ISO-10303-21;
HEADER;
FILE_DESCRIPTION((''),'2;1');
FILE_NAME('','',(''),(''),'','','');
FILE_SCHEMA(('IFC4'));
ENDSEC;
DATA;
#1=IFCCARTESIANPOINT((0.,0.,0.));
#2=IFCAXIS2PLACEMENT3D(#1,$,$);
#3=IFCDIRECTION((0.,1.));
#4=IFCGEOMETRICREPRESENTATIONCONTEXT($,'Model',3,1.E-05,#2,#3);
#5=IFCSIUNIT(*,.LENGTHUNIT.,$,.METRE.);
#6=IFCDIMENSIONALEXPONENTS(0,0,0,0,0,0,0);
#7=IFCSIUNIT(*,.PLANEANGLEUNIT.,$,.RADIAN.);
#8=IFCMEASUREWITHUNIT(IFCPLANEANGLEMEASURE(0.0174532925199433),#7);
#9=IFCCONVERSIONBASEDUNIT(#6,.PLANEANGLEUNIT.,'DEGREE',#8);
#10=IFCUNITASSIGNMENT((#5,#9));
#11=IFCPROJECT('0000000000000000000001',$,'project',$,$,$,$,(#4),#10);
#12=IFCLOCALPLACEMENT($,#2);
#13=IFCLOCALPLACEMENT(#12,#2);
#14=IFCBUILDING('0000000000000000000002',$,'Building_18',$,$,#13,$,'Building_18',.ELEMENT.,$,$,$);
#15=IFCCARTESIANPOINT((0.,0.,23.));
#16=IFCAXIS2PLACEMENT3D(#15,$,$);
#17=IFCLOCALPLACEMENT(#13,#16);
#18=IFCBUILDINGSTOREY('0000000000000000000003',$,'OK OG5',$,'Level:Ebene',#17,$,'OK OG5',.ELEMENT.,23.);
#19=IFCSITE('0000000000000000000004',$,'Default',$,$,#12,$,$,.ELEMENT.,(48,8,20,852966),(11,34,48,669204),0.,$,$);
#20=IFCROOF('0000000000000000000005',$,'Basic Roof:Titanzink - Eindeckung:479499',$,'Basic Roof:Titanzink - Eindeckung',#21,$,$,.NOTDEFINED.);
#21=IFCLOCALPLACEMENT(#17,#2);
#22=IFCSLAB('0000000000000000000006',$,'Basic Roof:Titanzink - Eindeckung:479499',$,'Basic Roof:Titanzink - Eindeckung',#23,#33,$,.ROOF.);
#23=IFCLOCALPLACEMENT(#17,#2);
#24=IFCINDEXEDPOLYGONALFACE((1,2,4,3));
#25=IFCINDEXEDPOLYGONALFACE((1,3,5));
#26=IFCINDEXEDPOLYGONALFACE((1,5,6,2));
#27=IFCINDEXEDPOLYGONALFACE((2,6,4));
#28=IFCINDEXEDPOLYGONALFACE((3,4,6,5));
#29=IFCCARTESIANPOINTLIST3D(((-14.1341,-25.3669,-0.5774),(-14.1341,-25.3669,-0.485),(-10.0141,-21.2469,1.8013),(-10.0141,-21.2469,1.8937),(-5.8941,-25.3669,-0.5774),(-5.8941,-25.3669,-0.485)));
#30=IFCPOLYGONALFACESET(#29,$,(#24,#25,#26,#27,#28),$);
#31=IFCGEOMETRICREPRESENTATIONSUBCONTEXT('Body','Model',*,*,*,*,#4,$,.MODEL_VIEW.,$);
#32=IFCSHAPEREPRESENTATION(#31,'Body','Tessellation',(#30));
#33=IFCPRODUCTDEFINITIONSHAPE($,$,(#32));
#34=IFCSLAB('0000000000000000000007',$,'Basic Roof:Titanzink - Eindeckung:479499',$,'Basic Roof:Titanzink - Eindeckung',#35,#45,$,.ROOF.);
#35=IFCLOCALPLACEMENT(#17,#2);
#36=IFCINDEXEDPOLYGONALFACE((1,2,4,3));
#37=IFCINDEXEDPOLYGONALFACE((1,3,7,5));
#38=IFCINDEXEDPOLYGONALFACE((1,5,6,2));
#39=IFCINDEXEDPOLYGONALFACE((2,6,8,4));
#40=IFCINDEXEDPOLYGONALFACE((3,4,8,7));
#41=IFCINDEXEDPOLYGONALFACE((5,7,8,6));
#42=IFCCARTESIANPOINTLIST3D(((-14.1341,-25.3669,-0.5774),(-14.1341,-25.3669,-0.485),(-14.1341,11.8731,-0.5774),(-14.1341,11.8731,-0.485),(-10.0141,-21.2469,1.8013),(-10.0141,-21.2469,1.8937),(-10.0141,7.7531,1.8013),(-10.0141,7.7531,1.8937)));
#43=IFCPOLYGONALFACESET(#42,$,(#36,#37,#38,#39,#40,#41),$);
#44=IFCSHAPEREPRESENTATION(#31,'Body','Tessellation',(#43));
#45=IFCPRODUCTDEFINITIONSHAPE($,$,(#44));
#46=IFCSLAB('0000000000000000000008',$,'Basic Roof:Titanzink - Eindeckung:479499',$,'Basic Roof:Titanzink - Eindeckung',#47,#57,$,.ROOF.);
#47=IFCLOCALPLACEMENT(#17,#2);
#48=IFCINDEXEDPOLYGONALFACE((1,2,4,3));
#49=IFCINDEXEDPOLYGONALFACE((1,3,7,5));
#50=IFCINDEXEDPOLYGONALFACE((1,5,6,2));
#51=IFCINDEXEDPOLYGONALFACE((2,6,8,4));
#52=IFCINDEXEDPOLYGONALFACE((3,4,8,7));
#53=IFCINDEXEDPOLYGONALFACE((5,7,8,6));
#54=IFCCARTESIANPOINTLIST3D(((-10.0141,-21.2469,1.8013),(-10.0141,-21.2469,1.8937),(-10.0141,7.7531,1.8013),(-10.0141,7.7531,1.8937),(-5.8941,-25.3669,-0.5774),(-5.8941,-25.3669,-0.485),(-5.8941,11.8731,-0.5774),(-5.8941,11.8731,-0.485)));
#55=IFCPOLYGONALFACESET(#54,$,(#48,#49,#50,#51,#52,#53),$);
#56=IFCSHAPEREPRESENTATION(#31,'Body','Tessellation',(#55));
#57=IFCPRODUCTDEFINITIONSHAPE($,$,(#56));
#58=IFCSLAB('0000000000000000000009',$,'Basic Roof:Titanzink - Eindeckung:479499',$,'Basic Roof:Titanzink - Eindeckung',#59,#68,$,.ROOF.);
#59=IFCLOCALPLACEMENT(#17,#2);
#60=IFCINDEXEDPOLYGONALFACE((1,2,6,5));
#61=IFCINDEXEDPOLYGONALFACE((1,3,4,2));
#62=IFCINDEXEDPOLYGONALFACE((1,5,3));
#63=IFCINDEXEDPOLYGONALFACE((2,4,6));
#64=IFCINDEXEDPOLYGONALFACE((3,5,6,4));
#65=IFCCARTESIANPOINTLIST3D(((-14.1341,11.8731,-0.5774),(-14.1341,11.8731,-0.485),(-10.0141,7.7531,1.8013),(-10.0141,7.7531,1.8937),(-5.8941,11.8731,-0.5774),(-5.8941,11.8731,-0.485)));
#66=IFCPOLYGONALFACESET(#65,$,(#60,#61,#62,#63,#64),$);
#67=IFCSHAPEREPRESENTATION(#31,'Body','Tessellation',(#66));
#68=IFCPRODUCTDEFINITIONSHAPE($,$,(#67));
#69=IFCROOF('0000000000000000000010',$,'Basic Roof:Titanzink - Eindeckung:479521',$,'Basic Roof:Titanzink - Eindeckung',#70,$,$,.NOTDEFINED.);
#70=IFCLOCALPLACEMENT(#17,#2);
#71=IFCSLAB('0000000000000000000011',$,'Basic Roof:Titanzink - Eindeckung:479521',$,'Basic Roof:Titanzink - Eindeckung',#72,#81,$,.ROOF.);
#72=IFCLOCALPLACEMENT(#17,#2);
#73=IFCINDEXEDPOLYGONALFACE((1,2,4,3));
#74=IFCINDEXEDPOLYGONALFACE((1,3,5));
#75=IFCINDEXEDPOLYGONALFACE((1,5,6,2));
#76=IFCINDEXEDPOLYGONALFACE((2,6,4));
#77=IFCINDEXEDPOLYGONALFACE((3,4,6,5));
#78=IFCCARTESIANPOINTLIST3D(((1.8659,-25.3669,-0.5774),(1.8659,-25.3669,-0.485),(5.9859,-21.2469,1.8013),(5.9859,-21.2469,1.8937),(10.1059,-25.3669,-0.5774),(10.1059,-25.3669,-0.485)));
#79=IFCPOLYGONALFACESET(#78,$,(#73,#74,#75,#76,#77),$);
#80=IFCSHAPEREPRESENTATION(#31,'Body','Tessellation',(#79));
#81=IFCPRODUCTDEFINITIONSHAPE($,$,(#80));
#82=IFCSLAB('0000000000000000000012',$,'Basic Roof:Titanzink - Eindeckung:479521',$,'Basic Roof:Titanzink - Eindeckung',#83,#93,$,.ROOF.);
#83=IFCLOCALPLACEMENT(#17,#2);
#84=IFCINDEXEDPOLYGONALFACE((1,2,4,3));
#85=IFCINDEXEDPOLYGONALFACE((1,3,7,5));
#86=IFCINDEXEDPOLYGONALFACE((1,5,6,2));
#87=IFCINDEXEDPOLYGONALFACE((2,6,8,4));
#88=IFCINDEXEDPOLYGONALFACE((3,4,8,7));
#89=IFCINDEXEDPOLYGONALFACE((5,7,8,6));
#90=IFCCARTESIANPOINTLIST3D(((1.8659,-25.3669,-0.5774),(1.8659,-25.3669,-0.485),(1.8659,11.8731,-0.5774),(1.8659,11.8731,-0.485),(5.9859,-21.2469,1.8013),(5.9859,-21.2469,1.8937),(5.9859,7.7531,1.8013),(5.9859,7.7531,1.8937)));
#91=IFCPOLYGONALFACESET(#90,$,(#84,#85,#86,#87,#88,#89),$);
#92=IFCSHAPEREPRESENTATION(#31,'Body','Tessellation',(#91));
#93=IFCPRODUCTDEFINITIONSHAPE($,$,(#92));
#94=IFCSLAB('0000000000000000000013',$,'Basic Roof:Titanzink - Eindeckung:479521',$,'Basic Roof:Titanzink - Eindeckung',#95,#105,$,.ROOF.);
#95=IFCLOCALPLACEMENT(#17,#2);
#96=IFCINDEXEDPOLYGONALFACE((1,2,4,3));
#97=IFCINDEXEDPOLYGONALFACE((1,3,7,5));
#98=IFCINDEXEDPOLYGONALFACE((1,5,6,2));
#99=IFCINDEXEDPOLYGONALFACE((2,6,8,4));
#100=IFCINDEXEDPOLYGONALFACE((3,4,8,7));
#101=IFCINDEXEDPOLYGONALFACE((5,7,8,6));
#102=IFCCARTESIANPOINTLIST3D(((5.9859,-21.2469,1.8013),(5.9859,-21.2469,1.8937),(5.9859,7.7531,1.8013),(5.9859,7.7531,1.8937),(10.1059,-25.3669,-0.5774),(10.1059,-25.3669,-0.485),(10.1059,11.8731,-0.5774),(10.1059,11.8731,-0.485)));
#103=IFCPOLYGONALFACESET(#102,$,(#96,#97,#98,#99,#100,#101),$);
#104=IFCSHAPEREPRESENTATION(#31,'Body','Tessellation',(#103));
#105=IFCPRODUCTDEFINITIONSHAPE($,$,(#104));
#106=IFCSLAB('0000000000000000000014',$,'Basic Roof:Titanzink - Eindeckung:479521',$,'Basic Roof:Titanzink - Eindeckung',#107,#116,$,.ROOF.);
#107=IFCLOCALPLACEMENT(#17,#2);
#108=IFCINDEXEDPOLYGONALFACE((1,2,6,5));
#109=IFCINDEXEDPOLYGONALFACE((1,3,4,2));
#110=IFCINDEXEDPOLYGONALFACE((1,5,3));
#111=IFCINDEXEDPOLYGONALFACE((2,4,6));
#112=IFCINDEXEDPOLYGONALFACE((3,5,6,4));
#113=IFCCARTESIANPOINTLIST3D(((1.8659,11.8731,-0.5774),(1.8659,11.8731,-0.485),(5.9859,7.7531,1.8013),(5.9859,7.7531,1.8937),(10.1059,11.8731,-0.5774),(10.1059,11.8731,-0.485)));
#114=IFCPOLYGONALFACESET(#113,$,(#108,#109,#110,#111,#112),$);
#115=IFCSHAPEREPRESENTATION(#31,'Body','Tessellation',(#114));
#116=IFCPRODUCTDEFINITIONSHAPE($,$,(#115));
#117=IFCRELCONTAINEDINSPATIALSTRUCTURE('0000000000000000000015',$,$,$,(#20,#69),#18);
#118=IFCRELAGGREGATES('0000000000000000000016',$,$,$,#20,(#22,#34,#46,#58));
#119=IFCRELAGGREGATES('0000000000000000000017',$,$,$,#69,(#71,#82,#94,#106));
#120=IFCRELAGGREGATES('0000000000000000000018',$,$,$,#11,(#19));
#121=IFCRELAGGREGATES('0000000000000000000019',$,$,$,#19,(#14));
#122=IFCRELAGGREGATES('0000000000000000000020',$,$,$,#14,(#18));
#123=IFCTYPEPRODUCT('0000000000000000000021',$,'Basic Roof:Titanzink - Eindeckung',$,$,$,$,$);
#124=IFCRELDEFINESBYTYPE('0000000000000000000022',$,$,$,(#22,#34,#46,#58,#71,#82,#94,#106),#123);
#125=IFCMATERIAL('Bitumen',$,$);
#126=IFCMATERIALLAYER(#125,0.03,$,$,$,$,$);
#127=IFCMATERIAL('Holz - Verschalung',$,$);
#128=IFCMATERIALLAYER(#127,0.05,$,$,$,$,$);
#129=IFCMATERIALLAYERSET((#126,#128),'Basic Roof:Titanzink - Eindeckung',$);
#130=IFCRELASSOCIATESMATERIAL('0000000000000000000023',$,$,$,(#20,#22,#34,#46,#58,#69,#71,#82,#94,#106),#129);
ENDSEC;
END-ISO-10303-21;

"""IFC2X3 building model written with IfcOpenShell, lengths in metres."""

from ifc_helpers import new_model, entity, si_unit, converted_unit, direction, frame, origin, place, context, subcontext, project, spatial, polyline, outline, extrude, material, layer, layer_set, type_object, element, aggregate, save


model = new_model("IFC2X3")

# Units and contexts
model_context = context("Model", 3, precision=1e-05, world=origin(), true_north=direction((0.0, 1.0)))
body_context = subcontext(model_context, "Body", "Model", "MODEL_VIEW")
ifc_project = project(units=[si_unit("LENGTHUNIT", "METRE"), converted_unit("PLANEANGLEUNIT", "DEGREE", entity("IfcPlaneAngleMeasure", 0.0174532925199433), si_unit("PLANEANGLEUNIT", "RADIAN"), dimensions=[0, 0, 0, 0, 0, 0, 0])], contexts=[model_context])

# Site, building, storey
site_placement = place(None, origin())
site = spatial("IfcSite", under=ifc_project, at=site_placement, Name="Default", CompositionType="ELEMENT", RefLatitude=(48, 8, 20, 852966), RefLongitude=(11, 34, 48, 669204), RefElevation=0.0)
building_placement = place(site_placement, origin())
building = spatial("IfcBuilding", under=site, at=building_placement, Name="Building_18", LongName="Building_18", CompositionType="ELEMENT")
storey_placement = place(building_placement, frame((0.0, 0.0, 23.0)))
storey = spatial("IfcBuildingStorey", under=building, at=storey_placement, Name="OK OG5", ObjectType="Level:Ebene", LongName="OK OG5", CompositionType="ELEMENT", Elevation=23.0)

# Roofs, slabs
ifc_material_1 = material(Name="Bitumen")
ifc_layer_1 = layer(ifc_material_1, 0.03)
ifc_material_2 = material(Name="Holz - Verschalung")
ifc_layer_2 = layer(ifc_material_2, 0.05)
ifc_layer_set = layer_set([ifc_layer_1, ifc_layer_2], Name="Basic Roof:Titanzink - Eindeckung")
roof_1_placement = place(storey_placement, frame((-14.1341, -25.3669, -0.5774)))
roof_1 = element("IfcRoof", 1, at=roof_1_placement, inside=storey, material=ifc_layer_set, Name="Basic Roof:Titanzink - Eindeckung:479499", ObjectType="Basic Roof:Titanzink - Eindeckung", ShapeType="NOTDEFINED")
type_product = type_object("IfcTypeProduct", Name="Basic Roof:Titanzink - Eindeckung")
slab_1_placement = place(roof_1_placement, origin())
slab_1 = element("IfcSlab", 2, at=slab_1_placement, type_object=type_product, material=ifc_layer_set, Name="Basic Roof:Titanzink - Eindeckung:479499", ObjectType="Basic Roof:Titanzink - Eindeckung", PredefinedType="ROOF", context=body_context, shape_type="SweptSolid", body=[
    extrude(outline(polyline([(0.0, 2.3787), (-4.12, -2.3787), (4.12, -2.3787), (0.0, 2.3787)])), frame((4.12, 2.06, 1.1893), z_axis=(0.0, -0.5, 0.866025), x_axis=(1.0, 0.0, 0.0)), (0.0, 0.5, 0.866025), 0.0924),
])
slab_2_placement = place(roof_1_placement, origin())
slab_2 = element("IfcSlab", 3, at=slab_2_placement, type_object=type_product, material=ifc_layer_set, Name="Basic Roof:Titanzink - Eindeckung:479499", ObjectType="Basic Roof:Titanzink - Eindeckung", PredefinedType="ROOF", context=body_context, shape_type="SweptSolid", body=[
    extrude(outline(polyline([(-2.3787, 18.62), (-2.3787, -18.62), (2.3787, -14.5), (2.3787, 14.5), (-2.3787, 18.62)])), frame((2.06, 18.62, 1.1893), z_axis=(-0.5, 0.0, 0.866025), x_axis=(0.866025, 0.0, 0.5)), (0.5, 0.0, 0.866025), 0.0924),
])
slab_3_placement = place(roof_1_placement, origin())
slab_3 = element("IfcSlab", 4, at=slab_3_placement, type_object=type_product, material=ifc_layer_set, Name="Basic Roof:Titanzink - Eindeckung:479499", ObjectType="Basic Roof:Titanzink - Eindeckung", PredefinedType="ROOF", context=body_context, shape_type="SweptSolid", body=[
    extrude(outline(polyline([(2.3787, -18.62), (2.3787, 18.62), (-2.3787, 14.5), (-2.3787, -14.5), (2.3787, -18.62)])), frame((6.18, 18.62, 1.1893), z_axis=(0.5, 0.0, 0.866025), x_axis=(0.866025, 0.0, -0.5)), (-0.5, 0.0, 0.866025), 0.0924),
])
slab_4_placement = place(roof_1_placement, origin())
slab_4 = element("IfcSlab", 5, at=slab_4_placement, type_object=type_product, material=ifc_layer_set, Name="Basic Roof:Titanzink - Eindeckung:479499", ObjectType="Basic Roof:Titanzink - Eindeckung", PredefinedType="ROOF", context=body_context, shape_type="SweptSolid", body=[
    extrude(outline(polyline([(4.12, 2.3787), (-4.12, 2.3787), (0.0, -2.3787), (4.12, 2.3787)])), frame((4.12, 35.18, 1.1893), z_axis=(0.0, 0.5, 0.866025), x_axis=(1.0, 0.0, 0.0)), (0.0, -0.5, 0.866025), 0.0924),
])
aggregate(roof_1, [slab_1, slab_2, slab_3, slab_4])
roof_2_placement = place(storey_placement, frame((1.8659, -25.3669, -0.5774)))
roof_2 = element("IfcRoof", 6, at=roof_2_placement, inside=storey, material=ifc_layer_set, Name="Basic Roof:Titanzink - Eindeckung:479521", ObjectType="Basic Roof:Titanzink - Eindeckung", ShapeType="NOTDEFINED")
slab_5_placement = place(roof_2_placement, origin())
slab_5 = element("IfcSlab", 7, at=slab_5_placement, type_object=type_product, material=ifc_layer_set, Name="Basic Roof:Titanzink - Eindeckung:479521", ObjectType="Basic Roof:Titanzink - Eindeckung", PredefinedType="ROOF", context=body_context, shape_type="SweptSolid", body=[
    extrude(outline(polyline([(0.0, 2.3787), (-4.12, -2.3787), (4.12, -2.3787), (0.0, 2.3787)])), frame((4.12, 2.06, 1.1893), z_axis=(0.0, -0.5, 0.866025), x_axis=(1.0, 0.0, 0.0)), (0.0, 0.5, 0.866025), 0.0924),
])
slab_6_placement = place(roof_2_placement, origin())
slab_6 = element("IfcSlab", 8, at=slab_6_placement, type_object=type_product, material=ifc_layer_set, Name="Basic Roof:Titanzink - Eindeckung:479521", ObjectType="Basic Roof:Titanzink - Eindeckung", PredefinedType="ROOF", context=body_context, shape_type="SweptSolid", body=[
    extrude(outline(polyline([(-2.3787, 18.62), (-2.3787, -18.62), (2.3787, -14.5), (2.3787, 14.5), (-2.3787, 18.62)])), frame((2.06, 18.62, 1.1893), z_axis=(-0.5, 0.0, 0.866025), x_axis=(0.866025, 0.0, 0.5)), (0.5, 0.0, 0.866025), 0.0924),
])
slab_7_placement = place(roof_2_placement, origin())
slab_7 = element("IfcSlab", 9, at=slab_7_placement, type_object=type_product, material=ifc_layer_set, Name="Basic Roof:Titanzink - Eindeckung:479521", ObjectType="Basic Roof:Titanzink - Eindeckung", PredefinedType="ROOF", context=body_context, shape_type="SweptSolid", body=[
    extrude(outline(polyline([(2.3787, -18.62), (2.3787, 18.62), (-2.3787, 14.5), (-2.3787, -14.5), (2.3787, -18.62)])), frame((6.18, 18.62, 1.1893), z_axis=(0.5, 0.0, 0.866025), x_axis=(0.866025, 0.0, -0.5)), (-0.5, 0.0, 0.866025), 0.0924),
])
slab_8_placement = place(roof_2_placement, origin())
slab_8 = element("IfcSlab", 10, at=slab_8_placement, type_object=type_product, material=ifc_layer_set, Name="Basic Roof:Titanzink - Eindeckung:479521", ObjectType="Basic Roof:Titanzink - Eindeckung", PredefinedType="ROOF", context=body_context, shape_type="SweptSolid", body=[
    extrude(outline(polyline([(4.12, 2.3787), (-4.12, 2.3787), (0.0, -2.3787), (4.12, 2.3787)])), frame((4.12, 35.18, 1.1893), z_axis=(0.0, 0.5, 0.866025), x_axis=(1.0, 0.0, 0.0)), (0.0, -0.5, 0.866025), 0.0924),
])
aggregate(roof_2, [slab_5, slab_6, slab_7, slab_8])

save(model, "model.ifc")
